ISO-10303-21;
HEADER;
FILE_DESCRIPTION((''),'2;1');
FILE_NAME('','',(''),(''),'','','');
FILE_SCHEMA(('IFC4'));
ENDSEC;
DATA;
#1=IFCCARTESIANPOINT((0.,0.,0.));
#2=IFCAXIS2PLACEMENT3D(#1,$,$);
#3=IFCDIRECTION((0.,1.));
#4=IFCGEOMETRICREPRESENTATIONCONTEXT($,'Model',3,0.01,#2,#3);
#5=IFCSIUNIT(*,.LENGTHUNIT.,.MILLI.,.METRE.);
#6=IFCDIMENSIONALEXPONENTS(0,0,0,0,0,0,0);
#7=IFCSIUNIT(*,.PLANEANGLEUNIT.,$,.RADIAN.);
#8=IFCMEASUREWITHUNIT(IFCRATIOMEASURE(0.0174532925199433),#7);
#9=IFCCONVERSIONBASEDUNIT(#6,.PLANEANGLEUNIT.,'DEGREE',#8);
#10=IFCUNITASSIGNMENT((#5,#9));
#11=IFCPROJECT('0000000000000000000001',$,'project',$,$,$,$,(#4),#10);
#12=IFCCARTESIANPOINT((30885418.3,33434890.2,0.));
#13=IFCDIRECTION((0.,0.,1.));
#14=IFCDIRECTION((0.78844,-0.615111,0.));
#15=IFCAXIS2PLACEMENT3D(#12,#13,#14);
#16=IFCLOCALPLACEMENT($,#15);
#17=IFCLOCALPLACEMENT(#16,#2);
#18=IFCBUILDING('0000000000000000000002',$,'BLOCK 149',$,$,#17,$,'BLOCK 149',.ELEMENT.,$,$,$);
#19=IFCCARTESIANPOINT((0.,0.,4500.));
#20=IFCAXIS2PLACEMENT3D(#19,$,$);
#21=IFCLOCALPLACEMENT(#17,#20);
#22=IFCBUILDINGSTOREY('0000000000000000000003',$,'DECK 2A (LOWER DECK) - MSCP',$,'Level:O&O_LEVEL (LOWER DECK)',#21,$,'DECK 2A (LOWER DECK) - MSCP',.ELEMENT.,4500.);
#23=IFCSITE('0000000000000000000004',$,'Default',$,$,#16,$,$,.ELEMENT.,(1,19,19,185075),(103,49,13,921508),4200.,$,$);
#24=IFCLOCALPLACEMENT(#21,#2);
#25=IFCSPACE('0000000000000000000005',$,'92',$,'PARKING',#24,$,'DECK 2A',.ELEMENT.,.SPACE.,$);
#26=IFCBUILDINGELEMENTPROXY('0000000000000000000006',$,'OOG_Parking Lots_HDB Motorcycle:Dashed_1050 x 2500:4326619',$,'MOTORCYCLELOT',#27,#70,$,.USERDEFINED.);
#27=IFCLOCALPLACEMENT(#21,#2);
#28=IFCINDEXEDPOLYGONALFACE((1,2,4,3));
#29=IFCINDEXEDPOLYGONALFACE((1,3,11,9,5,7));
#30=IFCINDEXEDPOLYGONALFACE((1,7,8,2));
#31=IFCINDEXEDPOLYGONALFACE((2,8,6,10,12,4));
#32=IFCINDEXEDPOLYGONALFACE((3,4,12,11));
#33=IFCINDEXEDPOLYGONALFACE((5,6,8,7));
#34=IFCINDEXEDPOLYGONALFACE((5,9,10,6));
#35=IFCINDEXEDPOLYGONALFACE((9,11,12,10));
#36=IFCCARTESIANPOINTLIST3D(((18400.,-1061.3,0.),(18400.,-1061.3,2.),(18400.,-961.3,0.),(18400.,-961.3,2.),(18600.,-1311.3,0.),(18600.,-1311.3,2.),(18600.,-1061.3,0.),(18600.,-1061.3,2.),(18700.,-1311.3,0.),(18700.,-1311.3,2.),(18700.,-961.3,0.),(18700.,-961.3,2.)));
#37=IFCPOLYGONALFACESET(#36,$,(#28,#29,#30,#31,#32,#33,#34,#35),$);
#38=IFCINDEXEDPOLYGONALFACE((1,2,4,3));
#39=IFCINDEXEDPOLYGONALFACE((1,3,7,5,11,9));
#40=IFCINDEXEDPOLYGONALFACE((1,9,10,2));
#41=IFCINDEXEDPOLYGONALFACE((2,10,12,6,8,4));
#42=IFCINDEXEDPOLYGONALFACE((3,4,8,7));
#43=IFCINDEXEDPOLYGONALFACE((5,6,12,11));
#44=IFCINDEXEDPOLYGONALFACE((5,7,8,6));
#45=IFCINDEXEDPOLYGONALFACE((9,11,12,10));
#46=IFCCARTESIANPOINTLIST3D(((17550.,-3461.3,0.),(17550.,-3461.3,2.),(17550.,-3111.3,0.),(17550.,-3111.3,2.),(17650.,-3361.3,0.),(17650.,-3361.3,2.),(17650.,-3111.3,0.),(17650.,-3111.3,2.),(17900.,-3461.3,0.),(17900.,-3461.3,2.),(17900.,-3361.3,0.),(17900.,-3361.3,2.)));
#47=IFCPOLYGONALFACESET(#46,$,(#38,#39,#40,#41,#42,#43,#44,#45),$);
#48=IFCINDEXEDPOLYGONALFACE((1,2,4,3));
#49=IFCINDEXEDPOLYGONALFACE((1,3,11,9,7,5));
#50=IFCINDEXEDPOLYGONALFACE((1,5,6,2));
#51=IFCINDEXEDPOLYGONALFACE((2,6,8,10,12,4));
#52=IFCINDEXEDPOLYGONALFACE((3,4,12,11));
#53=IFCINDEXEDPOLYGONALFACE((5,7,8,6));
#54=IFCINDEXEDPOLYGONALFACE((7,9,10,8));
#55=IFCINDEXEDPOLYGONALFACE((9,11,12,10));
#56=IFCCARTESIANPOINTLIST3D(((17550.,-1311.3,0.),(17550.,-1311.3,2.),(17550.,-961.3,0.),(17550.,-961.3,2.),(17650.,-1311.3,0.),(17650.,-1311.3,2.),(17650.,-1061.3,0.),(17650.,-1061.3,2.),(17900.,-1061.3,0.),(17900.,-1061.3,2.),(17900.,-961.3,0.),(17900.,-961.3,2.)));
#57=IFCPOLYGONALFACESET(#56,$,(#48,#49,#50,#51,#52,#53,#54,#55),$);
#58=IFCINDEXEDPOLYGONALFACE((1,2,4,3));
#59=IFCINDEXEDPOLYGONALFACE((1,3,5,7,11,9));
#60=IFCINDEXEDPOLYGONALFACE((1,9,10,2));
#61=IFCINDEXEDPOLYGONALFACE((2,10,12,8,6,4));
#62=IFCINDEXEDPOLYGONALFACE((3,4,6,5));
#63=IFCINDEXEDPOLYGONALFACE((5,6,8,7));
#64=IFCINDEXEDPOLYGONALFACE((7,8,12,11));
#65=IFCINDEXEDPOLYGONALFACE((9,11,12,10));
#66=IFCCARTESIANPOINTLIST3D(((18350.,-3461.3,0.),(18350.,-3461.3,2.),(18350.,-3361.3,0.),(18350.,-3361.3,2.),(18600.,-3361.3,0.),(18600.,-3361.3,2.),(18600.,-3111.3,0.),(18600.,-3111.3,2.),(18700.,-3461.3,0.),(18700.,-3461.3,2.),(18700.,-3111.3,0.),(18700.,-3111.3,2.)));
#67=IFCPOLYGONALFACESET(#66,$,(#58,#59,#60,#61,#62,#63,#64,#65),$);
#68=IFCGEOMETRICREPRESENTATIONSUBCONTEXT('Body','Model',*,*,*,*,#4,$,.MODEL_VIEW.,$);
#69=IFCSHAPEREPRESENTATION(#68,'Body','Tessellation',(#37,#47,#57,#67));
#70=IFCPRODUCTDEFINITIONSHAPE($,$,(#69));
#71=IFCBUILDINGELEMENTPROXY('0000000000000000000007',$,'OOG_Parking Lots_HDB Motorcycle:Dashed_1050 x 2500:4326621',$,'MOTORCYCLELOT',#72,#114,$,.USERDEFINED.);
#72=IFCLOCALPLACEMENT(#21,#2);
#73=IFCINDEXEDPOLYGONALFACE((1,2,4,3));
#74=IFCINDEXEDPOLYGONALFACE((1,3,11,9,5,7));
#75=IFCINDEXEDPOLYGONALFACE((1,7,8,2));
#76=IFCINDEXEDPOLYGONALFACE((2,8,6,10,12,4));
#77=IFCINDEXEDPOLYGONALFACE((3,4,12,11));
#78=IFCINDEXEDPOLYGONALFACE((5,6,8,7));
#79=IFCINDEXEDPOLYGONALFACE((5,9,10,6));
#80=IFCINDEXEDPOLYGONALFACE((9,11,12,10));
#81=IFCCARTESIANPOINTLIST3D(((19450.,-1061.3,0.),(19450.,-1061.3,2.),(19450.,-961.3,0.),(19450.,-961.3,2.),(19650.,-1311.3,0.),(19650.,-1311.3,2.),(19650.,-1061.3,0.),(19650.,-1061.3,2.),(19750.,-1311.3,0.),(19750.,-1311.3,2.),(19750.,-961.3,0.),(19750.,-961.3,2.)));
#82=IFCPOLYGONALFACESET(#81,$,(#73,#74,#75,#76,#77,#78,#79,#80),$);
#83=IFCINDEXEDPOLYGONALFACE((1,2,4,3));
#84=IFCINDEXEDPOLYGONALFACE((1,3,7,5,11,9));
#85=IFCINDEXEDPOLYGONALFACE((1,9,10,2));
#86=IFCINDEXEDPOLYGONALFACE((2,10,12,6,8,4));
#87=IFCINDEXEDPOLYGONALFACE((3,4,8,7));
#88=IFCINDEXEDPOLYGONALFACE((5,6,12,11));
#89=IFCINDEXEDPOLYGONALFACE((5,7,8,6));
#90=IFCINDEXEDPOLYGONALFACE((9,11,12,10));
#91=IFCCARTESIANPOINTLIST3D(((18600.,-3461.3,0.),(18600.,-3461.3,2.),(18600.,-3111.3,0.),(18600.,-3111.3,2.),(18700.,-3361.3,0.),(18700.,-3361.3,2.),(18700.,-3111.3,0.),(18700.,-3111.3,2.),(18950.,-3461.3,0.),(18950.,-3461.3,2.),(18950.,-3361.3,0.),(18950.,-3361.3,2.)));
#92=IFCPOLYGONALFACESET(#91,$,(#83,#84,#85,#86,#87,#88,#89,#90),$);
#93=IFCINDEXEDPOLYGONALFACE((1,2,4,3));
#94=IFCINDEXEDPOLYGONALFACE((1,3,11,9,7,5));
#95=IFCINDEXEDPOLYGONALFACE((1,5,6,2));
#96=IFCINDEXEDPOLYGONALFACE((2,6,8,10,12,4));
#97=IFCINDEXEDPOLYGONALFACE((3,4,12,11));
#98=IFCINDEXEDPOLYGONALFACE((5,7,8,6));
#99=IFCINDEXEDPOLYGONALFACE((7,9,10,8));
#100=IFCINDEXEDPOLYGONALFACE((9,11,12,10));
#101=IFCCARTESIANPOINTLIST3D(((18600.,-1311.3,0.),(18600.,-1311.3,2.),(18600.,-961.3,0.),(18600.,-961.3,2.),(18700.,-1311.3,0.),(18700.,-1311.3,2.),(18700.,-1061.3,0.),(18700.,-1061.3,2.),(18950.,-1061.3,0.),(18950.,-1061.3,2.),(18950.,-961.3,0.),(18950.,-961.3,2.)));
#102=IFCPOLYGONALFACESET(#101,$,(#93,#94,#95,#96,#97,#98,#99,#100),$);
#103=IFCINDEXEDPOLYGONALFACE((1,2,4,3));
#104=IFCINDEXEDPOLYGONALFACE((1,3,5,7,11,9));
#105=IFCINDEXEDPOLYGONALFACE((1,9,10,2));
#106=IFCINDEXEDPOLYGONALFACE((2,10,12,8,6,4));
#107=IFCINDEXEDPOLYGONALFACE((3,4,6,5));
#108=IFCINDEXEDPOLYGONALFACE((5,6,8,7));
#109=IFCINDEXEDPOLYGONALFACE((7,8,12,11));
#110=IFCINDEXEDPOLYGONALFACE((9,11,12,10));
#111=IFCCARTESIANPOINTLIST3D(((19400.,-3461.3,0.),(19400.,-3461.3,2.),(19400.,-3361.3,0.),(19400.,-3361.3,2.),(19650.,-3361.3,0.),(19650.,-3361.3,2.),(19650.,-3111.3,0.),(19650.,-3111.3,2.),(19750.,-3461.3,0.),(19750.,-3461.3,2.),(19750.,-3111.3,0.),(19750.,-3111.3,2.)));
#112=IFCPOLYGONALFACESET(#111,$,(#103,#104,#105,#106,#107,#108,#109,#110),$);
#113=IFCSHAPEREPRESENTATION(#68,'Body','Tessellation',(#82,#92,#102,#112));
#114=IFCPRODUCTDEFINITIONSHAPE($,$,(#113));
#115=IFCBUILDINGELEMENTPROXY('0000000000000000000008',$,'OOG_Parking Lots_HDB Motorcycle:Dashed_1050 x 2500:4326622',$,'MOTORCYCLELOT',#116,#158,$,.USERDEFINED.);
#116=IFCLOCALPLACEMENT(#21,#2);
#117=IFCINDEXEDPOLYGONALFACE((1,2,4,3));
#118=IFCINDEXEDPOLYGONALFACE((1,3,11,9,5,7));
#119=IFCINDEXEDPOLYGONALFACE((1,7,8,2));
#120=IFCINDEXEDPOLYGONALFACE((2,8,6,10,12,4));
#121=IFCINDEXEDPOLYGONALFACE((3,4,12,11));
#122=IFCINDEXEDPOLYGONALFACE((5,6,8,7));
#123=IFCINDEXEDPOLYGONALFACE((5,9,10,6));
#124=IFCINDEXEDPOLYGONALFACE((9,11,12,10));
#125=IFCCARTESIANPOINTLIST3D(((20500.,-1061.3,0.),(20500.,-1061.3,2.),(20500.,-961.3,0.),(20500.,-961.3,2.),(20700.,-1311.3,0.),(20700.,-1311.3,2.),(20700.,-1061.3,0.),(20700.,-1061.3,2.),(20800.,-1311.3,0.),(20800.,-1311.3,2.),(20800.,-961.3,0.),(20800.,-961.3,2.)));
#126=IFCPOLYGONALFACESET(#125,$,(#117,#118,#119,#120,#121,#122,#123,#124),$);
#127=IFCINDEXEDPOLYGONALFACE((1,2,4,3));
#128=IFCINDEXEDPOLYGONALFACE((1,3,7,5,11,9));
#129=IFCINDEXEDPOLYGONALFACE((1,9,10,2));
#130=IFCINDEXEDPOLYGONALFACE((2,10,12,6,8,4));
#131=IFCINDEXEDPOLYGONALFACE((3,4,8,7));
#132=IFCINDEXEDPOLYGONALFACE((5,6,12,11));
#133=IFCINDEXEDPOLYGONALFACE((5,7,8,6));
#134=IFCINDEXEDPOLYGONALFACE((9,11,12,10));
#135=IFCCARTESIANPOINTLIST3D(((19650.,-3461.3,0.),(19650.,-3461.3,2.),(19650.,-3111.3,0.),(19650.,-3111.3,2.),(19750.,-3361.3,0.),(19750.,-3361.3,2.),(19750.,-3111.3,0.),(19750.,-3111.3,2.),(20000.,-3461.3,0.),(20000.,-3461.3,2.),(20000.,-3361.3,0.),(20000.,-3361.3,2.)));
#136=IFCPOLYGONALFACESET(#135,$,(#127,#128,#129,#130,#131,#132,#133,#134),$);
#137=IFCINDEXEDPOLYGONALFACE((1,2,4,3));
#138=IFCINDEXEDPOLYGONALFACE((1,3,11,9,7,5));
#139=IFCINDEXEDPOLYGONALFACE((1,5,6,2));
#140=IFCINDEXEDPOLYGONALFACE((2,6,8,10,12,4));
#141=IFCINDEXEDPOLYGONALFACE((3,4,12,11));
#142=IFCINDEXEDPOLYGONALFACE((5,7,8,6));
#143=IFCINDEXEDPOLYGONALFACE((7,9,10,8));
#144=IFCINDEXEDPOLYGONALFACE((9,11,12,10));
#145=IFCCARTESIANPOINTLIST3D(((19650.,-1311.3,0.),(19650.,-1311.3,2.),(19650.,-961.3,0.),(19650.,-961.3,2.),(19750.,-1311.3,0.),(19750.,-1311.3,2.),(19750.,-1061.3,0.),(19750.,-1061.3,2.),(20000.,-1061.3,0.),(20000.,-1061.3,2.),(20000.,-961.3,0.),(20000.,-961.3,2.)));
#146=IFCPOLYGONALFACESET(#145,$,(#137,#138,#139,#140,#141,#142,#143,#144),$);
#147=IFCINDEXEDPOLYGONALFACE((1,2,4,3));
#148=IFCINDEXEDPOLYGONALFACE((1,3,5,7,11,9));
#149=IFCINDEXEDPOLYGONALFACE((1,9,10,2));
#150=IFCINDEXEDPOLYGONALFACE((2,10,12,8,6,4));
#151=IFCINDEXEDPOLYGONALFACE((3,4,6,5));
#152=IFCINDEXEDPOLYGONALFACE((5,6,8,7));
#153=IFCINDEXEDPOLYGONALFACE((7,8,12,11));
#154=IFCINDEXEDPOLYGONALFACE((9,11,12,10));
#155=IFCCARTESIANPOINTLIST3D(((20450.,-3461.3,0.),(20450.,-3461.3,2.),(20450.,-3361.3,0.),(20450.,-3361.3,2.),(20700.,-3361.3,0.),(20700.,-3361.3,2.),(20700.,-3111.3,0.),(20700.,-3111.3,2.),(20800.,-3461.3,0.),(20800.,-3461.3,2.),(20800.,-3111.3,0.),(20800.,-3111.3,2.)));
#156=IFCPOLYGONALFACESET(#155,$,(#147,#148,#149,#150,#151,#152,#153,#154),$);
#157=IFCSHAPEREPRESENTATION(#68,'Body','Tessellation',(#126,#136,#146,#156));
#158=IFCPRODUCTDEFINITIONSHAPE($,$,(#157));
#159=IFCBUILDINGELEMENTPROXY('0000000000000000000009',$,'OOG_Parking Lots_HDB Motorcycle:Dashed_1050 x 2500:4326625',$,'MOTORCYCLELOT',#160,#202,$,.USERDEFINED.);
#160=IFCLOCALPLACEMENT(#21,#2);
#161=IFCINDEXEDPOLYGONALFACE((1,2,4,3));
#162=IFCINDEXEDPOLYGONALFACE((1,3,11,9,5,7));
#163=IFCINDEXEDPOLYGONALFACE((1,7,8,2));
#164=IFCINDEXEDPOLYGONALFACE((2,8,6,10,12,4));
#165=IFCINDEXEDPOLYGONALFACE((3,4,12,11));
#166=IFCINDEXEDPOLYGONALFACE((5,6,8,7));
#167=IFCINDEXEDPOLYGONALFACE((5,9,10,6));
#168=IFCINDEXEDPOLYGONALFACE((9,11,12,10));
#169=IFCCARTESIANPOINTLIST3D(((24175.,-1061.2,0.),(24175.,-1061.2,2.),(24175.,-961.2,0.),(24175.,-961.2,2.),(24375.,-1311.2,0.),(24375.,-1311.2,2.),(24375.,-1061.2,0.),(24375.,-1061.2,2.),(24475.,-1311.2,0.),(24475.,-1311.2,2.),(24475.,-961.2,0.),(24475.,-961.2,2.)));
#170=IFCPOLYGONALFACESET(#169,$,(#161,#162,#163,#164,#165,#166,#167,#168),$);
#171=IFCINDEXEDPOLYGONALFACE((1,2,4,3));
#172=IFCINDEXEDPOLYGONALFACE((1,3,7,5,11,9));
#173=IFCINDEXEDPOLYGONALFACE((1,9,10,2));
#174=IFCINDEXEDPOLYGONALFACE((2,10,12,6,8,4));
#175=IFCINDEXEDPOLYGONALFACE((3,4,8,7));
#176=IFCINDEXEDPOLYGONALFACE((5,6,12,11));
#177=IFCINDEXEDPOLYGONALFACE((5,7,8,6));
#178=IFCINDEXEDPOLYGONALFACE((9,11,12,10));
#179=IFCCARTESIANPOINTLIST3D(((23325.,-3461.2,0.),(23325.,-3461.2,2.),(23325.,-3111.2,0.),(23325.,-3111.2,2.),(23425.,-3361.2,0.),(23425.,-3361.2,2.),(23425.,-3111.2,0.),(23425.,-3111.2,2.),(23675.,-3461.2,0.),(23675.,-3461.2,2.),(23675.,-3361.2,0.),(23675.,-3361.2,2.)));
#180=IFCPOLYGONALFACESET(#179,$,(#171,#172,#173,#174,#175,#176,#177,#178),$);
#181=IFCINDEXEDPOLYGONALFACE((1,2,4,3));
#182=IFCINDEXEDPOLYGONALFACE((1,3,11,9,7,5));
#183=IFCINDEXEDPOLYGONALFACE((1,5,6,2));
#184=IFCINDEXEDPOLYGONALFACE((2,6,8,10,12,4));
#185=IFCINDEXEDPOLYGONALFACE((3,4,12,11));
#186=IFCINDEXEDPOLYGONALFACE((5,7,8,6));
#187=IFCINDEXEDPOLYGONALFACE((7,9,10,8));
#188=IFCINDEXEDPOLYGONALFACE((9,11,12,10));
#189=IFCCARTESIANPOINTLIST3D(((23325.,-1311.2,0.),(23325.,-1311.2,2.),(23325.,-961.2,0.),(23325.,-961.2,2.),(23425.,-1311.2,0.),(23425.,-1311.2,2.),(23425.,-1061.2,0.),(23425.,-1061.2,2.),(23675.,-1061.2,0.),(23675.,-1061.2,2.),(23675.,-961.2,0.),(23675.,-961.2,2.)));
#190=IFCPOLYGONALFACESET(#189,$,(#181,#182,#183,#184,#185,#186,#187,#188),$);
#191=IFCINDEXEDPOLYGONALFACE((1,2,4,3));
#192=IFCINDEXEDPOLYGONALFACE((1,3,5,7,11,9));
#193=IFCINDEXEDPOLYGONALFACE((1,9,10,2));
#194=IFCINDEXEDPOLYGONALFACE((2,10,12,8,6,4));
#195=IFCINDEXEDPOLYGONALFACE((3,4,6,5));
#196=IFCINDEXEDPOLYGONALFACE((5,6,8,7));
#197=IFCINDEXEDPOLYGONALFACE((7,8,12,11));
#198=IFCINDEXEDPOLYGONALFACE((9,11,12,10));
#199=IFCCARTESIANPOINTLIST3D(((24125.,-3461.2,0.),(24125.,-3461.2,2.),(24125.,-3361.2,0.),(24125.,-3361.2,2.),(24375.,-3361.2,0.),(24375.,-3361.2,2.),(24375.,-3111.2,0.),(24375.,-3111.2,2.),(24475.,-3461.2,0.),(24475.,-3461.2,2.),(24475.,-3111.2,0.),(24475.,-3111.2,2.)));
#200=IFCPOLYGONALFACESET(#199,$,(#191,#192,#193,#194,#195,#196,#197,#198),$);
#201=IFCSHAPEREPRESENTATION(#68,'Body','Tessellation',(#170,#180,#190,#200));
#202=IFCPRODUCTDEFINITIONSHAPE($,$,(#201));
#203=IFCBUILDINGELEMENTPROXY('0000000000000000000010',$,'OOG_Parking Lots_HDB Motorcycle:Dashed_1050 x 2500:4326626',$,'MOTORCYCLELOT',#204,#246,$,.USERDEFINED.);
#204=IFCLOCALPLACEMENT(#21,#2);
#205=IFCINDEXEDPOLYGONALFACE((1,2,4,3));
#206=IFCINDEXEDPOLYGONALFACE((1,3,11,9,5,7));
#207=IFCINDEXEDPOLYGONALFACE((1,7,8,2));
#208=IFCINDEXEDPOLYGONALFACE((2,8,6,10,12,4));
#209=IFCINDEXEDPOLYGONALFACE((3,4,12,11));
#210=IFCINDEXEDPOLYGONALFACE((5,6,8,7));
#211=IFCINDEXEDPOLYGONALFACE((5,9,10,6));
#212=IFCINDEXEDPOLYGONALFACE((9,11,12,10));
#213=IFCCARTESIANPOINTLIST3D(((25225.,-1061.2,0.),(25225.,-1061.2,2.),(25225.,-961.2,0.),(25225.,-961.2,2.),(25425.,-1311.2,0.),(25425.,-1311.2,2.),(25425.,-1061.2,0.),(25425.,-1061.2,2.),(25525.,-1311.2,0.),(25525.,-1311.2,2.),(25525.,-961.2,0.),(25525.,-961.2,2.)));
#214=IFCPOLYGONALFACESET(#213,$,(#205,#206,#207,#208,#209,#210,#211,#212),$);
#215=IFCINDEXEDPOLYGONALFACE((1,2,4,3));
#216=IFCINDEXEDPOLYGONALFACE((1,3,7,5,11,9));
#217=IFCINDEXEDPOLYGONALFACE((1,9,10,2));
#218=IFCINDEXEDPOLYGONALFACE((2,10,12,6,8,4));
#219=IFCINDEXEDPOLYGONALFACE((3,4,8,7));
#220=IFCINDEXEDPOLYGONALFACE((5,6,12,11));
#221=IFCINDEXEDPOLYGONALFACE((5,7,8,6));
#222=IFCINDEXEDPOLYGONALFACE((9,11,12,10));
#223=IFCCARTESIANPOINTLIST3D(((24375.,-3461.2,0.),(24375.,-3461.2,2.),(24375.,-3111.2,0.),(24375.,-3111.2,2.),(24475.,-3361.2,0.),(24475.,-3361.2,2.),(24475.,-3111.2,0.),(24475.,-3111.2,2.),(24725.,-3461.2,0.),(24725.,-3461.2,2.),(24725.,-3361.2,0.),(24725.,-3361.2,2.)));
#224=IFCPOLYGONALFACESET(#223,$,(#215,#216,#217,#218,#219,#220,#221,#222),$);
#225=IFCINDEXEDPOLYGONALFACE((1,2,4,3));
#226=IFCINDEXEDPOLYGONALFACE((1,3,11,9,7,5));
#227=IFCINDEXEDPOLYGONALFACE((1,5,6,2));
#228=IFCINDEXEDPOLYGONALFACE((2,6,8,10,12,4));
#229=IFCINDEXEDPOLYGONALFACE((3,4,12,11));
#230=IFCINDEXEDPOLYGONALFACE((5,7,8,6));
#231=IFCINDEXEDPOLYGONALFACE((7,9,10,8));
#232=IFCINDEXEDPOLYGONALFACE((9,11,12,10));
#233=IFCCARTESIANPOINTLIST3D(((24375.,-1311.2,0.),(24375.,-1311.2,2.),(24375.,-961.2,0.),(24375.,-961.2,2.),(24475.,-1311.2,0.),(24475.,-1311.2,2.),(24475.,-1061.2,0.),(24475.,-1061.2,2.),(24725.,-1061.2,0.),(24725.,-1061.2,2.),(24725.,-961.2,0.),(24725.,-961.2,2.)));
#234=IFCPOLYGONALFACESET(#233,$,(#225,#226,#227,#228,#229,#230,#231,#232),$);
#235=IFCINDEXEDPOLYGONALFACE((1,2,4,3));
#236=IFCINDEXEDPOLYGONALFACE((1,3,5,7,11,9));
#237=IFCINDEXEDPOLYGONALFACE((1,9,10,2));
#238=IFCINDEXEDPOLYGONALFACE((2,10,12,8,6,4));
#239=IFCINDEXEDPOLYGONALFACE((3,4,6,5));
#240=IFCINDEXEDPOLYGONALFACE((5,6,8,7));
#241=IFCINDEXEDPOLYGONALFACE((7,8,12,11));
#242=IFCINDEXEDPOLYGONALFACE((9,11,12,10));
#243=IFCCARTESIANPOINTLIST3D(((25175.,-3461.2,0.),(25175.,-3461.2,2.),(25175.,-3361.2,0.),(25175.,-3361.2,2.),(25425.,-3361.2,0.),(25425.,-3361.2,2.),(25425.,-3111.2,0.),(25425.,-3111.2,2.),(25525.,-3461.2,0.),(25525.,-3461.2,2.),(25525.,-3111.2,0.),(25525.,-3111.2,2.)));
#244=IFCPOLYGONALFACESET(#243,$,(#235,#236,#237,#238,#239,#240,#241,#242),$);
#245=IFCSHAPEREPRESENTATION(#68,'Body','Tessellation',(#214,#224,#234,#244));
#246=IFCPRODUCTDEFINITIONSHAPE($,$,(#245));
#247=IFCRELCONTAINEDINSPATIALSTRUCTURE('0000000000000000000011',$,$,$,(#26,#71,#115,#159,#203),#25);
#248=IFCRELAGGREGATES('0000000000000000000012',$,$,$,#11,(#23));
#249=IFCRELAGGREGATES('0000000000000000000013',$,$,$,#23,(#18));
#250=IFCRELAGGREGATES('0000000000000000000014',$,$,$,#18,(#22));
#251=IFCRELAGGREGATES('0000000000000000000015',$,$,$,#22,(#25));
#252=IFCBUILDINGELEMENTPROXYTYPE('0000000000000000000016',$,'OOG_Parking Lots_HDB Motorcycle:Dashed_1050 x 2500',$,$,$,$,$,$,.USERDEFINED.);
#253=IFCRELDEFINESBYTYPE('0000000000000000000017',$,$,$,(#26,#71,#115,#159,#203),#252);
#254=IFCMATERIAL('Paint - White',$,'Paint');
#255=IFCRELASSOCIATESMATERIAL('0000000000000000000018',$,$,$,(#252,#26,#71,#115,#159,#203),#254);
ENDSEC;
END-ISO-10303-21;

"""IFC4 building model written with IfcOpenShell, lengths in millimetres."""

from ifc_helpers import new_model, entity, si_unit, converted_unit, direction, frame, origin, place, context, subcontext, project, spatial, indexed_curve, outline, extrude, source, transform, mapped, material, type_object, type_shapes, element, save


model = new_model("IFC4")

# Units and contexts
model_context = context("Model", 3, precision=0.01, world=origin(), true_north=direction((0.0, 1.0)))
body_context = subcontext(model_context, "Body", "Model", "MODEL_VIEW")
ifc_project = project(units=[si_unit("LENGTHUNIT", "METRE", prefix="MILLI"), converted_unit("PLANEANGLEUNIT", "DEGREE", entity("IfcRatioMeasure", 0.0174532925199433), si_unit("PLANEANGLEUNIT", "RADIAN"), dimensions=[0, 0, 0, 0, 0, 0, 0])], contexts=[model_context])

# Site, building, storey
site_placement = place(None, frame((30885418.3, 33434890.2, 0.0), z_axis=(0.0, 0.0, 1.0), x_axis=(0.78844, -0.615111, 0.0)))
site = spatial("IfcSite", under=ifc_project, at=site_placement, Name="Default", CompositionType="ELEMENT", RefLatitude=(1, 19, 19, 185075), RefLongitude=(103, 49, 13, 921508), RefElevation=4200.0)
building_placement = place(site_placement, origin())
building = spatial("IfcBuilding", under=site, at=building_placement, Name="BLOCK 149", LongName="BLOCK 149", CompositionType="ELEMENT")
storey_placement = place(building_placement, frame((0.0, 0.0, 4500.0)))
storey = spatial("IfcBuildingStorey", under=building, at=storey_placement, Name="DECK 2A (LOWER DECK) - MSCP", ObjectType="Level:O&O_LEVEL (LOWER DECK)", LongName="DECK 2A (LOWER DECK) - MSCP", CompositionType="ELEMENT", Elevation=4500.0)

# Shared definitions
space_placement = place(storey_placement, origin())
space = spatial("IfcSpace", under=storey, at=space_placement, Name="92", ObjectType="PARKING", LongName="DECK 2A", CompositionType="ELEMENT", PredefinedType="SPACE")

# Building element proxies
ifc_material_1 = material(Name="Paint - White", Category="Paint")
building_element_proxy_type_1 = type_object("IfcBuildingElementProxyType", Name="OOG_Parking Lots_HDB Motorcycle:Dashed_1050 x 2500", PredefinedType="USERDEFINED", material=ifc_material_1)
shared_shape_1 = source(origin(), body_context, "Body", "SweptSolid", [
    extrude(outline(indexed_curve([(-200.0, -133.3), (150.0, -133.3), (150.0, 166.7), (50.0, 166.7), (50.0, -33.3), (-200.0, -33.3), (-200.0, -133.3)], self_intersect=False)), frame((966.7, -100.0, 0.0), z_axis=(0.0, 0.0, 1.0), x_axis=(0.0, 1.0, 0.0)), (0.0, 0.0, 1.0), 2.0),
    extrude(outline(indexed_curve([(-200.0, -150.0), (150.0, -150.0), (150.0, 200.0), (50.0, 200.0), (50.0, -50.0), (-200.0, -50.0), (-200.0, -150.0)], self_intersect=False)), frame((100.0, -2300.0, 0.0), z_axis=(0.0, 0.0, 1.0), x_axis=(0.0, -1.0, 0.0)), (0.0, 0.0, 1.0), 2.0),
    extrude(outline(indexed_curve([(-200.0, -150.0), (150.0, -150.0), (150.0, 200.0), (50.0, 200.0), (50.0, -50.0), (-200.0, -50.0), (-200.0, -150.0)], self_intersect=False)), frame((100.0, -100.0, 0.0), z_axis=(0.0, 0.0, 1.0), x_axis=(-1.0, 0.0, 0.0)), (0.0, 0.0, 1.0), 2.0),
    extrude(outline(indexed_curve([(-200.0, -150.0), (150.0, -150.0), (150.0, 200.0), (50.0, 200.0), (50.0, -50.0), (-200.0, -50.0), (-200.0, -150.0)], self_intersect=False)), frame((950.0, -2300.0, 0.0)), (0.0, 0.0, 1.0), 2.0),
])
type_shapes(building_element_proxy_type_1, [shared_shape_1])
for number, where, name in (
    (1, (17600.0, -1011.3, 0.0), "OOG_Parking Lots_HDB Motorcycle:Dashed_1050 x 2500:4326619"),
    (2, (18650.0, -1011.3, 0.0), "OOG_Parking Lots_HDB Motorcycle:Dashed_1050 x 2500:4326621"),
    (3, (19700.0, -1011.3, 0.0), "OOG_Parking Lots_HDB Motorcycle:Dashed_1050 x 2500:4326622"),
    (4, (23375.0, -1011.2, 0.0), "OOG_Parking Lots_HDB Motorcycle:Dashed_1050 x 2500:4326625"),
    (5, (24425.0, -1011.2, 0.0), "OOG_Parking Lots_HDB Motorcycle:Dashed_1050 x 2500:4326626"),
):
    element("IfcBuildingElementProxy", number, at=place(space_placement, frame(where)), inside=space, type_object=building_element_proxy_type_1, material=ifc_material_1, Name=name, ObjectType="MOTORCYCLELOT", PredefinedType="USERDEFINED", context=body_context, shape_type="MappedRepresentation", body=[
        mapped(shared_shape_1, transform((0.0, 0.0, 0.0), scale=1.0)),
    ])

save(model, "model.ifc")
